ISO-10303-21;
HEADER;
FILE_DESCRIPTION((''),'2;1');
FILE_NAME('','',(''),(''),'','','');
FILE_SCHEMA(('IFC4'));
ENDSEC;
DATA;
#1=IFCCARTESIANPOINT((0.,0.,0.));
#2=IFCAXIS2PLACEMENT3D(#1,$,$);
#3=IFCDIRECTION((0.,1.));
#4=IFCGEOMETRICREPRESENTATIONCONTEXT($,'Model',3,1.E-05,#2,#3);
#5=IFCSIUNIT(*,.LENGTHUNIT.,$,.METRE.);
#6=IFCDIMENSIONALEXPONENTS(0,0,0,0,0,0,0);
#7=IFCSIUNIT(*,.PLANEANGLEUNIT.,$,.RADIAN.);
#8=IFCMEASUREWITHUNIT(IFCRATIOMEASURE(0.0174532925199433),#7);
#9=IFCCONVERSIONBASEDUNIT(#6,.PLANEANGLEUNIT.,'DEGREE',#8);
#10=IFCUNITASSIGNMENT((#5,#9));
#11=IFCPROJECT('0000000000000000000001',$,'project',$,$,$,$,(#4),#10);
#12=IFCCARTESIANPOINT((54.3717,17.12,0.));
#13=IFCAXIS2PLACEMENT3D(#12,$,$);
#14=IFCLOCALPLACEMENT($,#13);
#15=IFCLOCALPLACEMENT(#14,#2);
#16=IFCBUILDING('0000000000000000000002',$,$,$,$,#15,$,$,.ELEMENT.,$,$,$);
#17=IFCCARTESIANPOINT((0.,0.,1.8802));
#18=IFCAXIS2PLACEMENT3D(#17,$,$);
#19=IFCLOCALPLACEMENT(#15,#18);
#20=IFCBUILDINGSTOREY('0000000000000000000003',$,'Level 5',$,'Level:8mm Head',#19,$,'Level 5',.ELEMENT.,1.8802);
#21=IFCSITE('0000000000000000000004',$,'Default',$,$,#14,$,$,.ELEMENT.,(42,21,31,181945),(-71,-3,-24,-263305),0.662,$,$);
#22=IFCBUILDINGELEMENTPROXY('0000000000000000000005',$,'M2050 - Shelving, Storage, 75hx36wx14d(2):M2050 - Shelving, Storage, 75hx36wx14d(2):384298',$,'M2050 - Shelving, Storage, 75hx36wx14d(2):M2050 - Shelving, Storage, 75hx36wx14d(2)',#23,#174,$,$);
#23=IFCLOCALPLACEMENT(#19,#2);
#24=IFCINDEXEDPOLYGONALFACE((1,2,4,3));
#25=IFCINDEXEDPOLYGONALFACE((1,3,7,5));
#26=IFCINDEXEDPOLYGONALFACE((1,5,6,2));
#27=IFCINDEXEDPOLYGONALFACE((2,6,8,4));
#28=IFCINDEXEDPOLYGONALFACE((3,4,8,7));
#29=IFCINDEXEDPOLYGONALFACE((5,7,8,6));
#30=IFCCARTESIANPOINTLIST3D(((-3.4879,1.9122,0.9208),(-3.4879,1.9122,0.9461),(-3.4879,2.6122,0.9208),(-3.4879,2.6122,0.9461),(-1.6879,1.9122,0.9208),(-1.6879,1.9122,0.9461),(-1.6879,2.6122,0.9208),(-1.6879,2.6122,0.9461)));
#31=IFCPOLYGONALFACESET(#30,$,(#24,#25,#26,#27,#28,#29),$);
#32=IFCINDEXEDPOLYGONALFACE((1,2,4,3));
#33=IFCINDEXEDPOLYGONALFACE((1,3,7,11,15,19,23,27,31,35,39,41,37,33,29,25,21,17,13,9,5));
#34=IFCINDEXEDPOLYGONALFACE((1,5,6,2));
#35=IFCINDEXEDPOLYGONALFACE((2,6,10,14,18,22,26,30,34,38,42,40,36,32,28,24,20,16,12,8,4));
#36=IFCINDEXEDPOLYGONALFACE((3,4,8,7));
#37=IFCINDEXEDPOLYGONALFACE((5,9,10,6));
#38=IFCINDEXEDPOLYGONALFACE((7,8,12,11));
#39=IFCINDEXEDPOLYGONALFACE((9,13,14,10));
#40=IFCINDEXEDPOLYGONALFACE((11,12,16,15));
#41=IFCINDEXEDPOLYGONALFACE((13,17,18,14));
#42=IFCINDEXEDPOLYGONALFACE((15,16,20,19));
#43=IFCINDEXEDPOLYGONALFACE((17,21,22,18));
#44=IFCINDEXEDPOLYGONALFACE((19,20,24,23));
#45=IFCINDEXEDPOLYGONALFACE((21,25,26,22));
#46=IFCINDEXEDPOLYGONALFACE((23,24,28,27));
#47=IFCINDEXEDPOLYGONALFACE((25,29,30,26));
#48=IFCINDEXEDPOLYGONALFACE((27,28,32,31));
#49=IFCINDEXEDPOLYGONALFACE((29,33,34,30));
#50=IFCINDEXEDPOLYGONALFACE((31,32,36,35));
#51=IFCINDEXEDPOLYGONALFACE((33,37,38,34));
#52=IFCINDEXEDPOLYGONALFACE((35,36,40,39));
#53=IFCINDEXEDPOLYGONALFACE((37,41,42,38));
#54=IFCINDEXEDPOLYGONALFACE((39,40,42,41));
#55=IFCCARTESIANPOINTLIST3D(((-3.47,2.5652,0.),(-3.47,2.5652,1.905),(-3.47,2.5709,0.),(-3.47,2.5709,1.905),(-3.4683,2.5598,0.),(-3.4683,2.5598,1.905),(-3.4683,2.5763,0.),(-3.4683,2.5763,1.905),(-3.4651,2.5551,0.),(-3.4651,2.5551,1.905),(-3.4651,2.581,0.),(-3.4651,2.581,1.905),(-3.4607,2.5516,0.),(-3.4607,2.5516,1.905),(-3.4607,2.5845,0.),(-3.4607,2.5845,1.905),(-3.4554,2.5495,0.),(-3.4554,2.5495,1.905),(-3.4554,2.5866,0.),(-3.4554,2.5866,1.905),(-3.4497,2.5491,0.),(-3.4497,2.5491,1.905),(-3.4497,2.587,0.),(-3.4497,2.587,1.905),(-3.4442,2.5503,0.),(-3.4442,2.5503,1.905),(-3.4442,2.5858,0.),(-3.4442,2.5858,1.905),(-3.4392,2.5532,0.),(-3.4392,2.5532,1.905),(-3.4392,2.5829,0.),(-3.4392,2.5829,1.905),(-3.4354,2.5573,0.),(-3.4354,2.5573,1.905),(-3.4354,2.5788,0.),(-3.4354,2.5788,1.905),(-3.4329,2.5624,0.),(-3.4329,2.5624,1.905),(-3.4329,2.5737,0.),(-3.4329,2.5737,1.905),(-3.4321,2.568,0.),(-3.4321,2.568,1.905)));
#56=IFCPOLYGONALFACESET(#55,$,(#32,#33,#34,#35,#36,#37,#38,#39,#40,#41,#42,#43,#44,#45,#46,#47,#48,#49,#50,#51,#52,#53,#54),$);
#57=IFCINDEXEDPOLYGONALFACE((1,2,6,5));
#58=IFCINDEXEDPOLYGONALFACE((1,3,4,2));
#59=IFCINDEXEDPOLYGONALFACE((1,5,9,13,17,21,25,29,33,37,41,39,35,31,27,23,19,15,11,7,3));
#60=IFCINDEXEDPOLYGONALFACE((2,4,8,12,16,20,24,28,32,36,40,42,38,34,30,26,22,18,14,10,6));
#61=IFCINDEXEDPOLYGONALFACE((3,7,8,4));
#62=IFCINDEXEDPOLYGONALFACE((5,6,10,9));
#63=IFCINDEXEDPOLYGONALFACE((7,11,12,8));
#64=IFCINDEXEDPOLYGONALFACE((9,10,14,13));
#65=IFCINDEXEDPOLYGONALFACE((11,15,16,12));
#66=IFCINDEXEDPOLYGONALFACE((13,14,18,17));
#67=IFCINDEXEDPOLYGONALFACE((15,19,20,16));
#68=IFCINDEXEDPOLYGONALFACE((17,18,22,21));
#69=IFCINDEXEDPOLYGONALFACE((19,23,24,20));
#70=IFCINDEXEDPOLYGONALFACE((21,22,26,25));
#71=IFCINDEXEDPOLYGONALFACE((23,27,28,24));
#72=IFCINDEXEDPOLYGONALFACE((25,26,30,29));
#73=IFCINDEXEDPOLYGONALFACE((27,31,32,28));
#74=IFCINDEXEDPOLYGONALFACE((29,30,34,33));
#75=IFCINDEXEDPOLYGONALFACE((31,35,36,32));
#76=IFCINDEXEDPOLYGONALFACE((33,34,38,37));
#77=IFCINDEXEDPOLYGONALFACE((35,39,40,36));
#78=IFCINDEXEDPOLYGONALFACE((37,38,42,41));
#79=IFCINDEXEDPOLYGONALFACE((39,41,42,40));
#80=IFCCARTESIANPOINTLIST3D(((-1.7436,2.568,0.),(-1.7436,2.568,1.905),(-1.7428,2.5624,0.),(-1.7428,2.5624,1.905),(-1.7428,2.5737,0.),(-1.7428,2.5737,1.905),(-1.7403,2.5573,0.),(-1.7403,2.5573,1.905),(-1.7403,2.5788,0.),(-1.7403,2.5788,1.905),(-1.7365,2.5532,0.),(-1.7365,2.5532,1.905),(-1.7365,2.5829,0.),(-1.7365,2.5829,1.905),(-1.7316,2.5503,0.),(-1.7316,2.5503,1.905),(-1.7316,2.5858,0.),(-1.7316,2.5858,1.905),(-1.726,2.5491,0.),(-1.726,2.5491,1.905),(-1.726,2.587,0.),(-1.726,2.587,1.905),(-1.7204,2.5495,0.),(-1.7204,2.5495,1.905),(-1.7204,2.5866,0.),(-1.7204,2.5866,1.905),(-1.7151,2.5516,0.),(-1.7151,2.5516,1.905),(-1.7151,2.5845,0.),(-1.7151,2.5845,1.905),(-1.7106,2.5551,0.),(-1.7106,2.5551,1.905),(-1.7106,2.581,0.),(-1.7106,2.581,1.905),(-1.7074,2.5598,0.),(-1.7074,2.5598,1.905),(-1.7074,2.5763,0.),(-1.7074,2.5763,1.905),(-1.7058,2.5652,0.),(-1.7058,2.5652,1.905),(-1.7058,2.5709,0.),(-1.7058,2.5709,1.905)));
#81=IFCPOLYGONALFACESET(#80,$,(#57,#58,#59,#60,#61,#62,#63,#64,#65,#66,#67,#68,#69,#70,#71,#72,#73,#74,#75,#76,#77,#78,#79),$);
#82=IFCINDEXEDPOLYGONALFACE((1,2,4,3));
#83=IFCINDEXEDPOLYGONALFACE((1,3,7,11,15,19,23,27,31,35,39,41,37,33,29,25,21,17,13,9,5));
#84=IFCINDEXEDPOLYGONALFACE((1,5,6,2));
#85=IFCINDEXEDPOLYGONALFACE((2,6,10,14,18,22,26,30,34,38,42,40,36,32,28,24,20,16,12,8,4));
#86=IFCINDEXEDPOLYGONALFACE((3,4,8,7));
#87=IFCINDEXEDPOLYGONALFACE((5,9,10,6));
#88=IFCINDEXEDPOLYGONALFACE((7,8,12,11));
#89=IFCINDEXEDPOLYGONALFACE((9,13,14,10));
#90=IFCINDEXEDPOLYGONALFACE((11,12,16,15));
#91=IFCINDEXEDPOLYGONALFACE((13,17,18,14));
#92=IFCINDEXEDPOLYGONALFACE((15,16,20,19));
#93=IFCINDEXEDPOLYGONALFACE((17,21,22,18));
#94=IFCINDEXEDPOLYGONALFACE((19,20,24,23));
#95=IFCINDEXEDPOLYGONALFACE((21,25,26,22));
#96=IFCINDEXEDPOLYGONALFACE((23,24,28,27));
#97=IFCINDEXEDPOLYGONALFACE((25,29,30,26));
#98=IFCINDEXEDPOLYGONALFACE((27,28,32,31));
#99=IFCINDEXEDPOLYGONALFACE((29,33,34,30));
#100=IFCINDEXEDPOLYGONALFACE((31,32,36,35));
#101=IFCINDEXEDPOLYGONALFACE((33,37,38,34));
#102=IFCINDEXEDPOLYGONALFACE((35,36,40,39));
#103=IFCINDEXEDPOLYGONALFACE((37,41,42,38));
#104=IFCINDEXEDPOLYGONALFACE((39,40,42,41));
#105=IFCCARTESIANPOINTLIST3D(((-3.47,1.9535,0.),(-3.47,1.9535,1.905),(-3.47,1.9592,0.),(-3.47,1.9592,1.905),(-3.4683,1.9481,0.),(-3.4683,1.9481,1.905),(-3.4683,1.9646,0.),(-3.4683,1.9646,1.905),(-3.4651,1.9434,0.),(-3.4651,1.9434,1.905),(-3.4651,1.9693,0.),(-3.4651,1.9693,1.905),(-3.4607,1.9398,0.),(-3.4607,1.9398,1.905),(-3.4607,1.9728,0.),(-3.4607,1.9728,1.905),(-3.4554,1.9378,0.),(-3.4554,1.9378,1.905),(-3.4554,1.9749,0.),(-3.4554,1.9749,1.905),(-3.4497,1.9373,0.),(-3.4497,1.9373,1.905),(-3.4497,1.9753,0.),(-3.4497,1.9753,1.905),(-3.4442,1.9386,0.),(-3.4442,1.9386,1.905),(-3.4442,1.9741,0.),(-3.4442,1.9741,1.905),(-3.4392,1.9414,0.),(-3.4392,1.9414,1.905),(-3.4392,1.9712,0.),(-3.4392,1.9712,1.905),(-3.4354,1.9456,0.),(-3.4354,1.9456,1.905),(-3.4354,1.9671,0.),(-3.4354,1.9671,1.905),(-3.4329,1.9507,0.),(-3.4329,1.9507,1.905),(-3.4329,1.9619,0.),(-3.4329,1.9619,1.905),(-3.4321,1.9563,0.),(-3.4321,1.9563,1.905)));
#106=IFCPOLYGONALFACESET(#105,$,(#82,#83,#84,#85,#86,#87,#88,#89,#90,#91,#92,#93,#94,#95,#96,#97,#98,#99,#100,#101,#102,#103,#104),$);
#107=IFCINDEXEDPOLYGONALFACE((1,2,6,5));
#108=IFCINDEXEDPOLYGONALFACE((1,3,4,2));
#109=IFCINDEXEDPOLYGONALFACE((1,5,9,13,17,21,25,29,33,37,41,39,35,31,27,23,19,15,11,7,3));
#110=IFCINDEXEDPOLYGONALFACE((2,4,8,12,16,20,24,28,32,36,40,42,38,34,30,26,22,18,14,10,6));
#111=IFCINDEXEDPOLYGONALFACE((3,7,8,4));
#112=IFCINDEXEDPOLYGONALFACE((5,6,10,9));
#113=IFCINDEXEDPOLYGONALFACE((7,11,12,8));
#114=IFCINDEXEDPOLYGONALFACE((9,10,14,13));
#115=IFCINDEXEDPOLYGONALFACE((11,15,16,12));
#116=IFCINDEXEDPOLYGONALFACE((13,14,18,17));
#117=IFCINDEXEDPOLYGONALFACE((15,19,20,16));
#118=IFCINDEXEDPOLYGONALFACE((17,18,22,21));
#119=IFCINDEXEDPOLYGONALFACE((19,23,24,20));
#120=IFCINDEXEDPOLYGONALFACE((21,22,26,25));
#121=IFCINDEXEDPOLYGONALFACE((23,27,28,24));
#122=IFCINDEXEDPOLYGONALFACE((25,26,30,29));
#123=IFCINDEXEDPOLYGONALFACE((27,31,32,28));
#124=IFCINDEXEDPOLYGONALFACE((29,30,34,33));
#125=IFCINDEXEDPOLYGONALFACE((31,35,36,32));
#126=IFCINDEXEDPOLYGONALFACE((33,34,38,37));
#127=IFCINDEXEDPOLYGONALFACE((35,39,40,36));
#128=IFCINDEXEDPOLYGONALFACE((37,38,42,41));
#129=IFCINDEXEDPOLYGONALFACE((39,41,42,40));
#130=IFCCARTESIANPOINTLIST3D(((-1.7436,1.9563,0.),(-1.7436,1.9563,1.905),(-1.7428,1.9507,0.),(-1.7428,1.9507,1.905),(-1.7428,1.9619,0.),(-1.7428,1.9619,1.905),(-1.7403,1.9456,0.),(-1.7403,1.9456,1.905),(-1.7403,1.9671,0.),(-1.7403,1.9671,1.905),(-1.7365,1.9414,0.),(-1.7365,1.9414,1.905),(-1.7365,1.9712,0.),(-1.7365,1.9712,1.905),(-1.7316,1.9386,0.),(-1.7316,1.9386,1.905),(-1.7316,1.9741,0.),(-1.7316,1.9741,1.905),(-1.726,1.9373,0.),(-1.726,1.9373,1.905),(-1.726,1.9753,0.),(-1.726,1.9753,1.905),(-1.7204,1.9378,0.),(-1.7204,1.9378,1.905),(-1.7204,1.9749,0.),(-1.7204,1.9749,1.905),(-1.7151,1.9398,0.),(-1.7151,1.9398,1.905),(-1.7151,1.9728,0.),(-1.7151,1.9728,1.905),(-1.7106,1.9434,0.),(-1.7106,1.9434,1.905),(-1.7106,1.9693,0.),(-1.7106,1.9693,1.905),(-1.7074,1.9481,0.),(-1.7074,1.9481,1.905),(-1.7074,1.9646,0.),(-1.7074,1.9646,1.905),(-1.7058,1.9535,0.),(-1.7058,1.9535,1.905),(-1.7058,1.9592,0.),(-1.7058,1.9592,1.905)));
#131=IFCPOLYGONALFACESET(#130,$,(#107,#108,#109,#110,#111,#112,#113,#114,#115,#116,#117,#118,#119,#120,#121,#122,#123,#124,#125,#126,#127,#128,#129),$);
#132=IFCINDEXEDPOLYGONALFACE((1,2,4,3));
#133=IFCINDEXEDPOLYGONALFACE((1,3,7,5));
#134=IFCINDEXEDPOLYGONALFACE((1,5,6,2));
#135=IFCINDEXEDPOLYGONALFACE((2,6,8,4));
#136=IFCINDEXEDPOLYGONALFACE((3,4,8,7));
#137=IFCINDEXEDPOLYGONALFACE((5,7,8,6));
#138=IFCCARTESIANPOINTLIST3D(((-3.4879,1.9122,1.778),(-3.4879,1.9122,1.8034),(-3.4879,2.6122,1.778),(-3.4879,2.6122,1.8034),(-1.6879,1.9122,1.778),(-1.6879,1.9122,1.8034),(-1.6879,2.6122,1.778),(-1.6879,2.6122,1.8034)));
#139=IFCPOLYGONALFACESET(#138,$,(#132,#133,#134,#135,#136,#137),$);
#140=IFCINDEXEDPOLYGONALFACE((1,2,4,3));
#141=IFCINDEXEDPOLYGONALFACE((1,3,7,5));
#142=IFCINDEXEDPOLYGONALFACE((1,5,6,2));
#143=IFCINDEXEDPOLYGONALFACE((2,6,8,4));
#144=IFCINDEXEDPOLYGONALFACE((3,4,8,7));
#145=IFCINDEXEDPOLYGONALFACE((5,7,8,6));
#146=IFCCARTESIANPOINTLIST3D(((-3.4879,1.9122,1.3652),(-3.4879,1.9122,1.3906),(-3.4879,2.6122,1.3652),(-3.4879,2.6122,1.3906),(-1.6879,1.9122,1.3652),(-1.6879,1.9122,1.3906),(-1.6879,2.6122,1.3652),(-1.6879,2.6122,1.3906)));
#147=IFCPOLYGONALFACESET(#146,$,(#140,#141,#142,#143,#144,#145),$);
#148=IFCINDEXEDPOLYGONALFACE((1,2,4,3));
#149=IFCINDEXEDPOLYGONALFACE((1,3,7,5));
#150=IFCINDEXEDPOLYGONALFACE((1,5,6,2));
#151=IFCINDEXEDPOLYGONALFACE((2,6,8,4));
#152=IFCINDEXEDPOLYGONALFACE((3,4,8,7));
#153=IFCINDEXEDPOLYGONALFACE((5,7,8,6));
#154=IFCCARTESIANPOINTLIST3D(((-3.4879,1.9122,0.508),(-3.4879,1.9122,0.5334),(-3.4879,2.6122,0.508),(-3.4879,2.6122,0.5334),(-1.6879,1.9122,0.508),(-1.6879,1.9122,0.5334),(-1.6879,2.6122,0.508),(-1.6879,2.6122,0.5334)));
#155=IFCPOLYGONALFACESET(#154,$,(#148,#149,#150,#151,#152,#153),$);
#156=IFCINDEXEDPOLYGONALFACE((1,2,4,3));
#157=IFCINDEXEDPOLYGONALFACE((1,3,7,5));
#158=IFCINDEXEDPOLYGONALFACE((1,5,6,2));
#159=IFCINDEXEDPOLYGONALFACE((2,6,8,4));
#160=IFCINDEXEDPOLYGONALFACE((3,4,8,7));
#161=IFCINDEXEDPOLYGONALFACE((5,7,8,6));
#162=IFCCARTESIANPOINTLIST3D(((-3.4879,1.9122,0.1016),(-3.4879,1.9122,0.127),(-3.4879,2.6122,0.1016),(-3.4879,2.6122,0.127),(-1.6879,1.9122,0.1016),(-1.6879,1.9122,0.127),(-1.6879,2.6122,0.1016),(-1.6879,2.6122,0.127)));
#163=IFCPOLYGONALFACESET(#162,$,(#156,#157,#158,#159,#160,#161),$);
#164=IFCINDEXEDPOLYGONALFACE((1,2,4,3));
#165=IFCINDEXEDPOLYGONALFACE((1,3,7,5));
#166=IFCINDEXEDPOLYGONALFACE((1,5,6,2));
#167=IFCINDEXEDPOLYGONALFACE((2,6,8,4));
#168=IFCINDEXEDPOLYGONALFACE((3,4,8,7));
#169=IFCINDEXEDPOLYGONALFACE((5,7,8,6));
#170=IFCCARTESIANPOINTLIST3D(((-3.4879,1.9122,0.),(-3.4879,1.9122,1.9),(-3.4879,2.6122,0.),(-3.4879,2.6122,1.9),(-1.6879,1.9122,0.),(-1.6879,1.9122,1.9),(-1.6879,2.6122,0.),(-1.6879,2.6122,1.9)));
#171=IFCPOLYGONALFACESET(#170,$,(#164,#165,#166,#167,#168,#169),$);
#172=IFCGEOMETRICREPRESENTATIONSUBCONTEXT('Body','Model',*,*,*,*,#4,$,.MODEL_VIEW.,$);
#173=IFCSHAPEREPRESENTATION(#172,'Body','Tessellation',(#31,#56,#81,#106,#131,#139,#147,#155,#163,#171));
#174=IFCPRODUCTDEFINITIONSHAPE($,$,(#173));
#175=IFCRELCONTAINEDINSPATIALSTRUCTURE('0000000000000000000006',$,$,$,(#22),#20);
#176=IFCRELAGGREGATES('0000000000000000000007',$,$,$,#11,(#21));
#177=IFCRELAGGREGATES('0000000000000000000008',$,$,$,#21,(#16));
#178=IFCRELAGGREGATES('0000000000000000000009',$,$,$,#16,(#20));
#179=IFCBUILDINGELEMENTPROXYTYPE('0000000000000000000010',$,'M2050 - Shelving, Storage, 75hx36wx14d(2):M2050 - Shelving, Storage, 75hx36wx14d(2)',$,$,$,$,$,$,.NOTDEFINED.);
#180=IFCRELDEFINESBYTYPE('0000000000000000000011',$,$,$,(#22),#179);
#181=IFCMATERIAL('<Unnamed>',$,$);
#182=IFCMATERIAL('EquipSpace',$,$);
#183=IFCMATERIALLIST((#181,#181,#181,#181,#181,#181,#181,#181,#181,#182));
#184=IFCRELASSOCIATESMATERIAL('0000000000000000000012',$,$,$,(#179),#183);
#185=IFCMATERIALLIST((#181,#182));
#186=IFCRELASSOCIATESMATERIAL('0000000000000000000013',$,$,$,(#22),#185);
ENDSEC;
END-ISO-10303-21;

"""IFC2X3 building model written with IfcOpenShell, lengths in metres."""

from ifc_helpers import new_model, entity, si_unit, converted_unit, direction, frame, frame_2d, origin, origin_2d_with_axis, place, context, subcontext, project, spatial, rectangle, circle, extrude, source, transform, mapped, material, material_list, type_object, type_shapes, element, save


model = new_model("IFC2X3")

# Units and contexts
model_context = context("Model", 3, precision=1e-05, world=origin(), true_north=direction((0.0, 1.0)))
body_context = subcontext(model_context, "Body", "Model", "MODEL_VIEW")
ifc_project = project(units=[si_unit("LENGTHUNIT", "METRE"), converted_unit("PLANEANGLEUNIT", "DEGREE", entity("IfcRatioMeasure", 0.0174532925199433), si_unit("PLANEANGLEUNIT", "RADIAN"), dimensions=[0, 0, 0, 0, 0, 0, 0])], contexts=[model_context])

# Site, building, storey
site_placement = place(None, frame((54.3717, 17.12, 0.0)))
site = spatial("IfcSite", under=ifc_project, at=site_placement, Name="Default", CompositionType="ELEMENT", RefLatitude=(42, 21, 31, 181945), RefLongitude=(-71, -3, -24, -263305), RefElevation=0.662)
building_placement = place(site_placement, origin())
building = spatial("IfcBuilding", under=site, at=building_placement, CompositionType="ELEMENT")
storey_placement = place(building_placement, frame((0.0, 0.0, 1.8802)))
storey = spatial("IfcBuildingStorey", under=building, at=storey_placement, Name="Level 5", ObjectType="Level:8mm Head", LongName="Level 5", CompositionType="ELEMENT", Elevation=1.8802)

# Building element proxy
ifc_material_1 = material(Name="<Unnamed>")
ifc_material_2 = material(Name="EquipSpace")
ifc_material_list_1 = material_list([ifc_material_1, ifc_material_1, ifc_material_1, ifc_material_1, ifc_material_1, ifc_material_1, ifc_material_1, ifc_material_1, ifc_material_1, ifc_material_2])
building_element_proxy_type = type_object("IfcBuildingElementProxyType", Name="M2050 - Shelving, Storage, 75hx36wx14d(2):M2050 - Shelving, Storage, 75hx36wx14d(2)", PredefinedType="NOTDEFINED", material=ifc_material_list_1)
shared_shape = source(origin(), body_context, "Body", "SweptSolid", [
    extrude(rectangle(XDim=1.8, YDim=0.7, at=origin_2d_with_axis()), frame((0.0, 0.0, 0.9207), z_axis=(0.0, 0.0, 1.0), x_axis=(-1.0, 0.0, 0.0)), (0.0, 0.0, 1.0), 0.0254),
    extrude(circle(Radius=0.0191, at=origin_2d_with_axis()), frame((0.8633, -0.3059, 0.0), z_axis=(0.0, 0.0, 1.0), x_axis=(-1.0, 0.0, 0.0)), (0.0, 0.0, 1.0), 1.905),
    extrude(circle(Radius=0.0191, at=origin_2d_with_axis()), frame((-0.8633, -0.3059, 0.0)), (0.0, 0.0, 1.0), 1.905),
    extrude(circle(Radius=0.0191, at=origin_2d_with_axis()), frame((0.8633, 0.3059, 0.0), z_axis=(0.0, 0.0, 1.0), x_axis=(-1.0, 0.0, 0.0)), (0.0, 0.0, 1.0), 1.905),
    extrude(circle(Radius=0.0191, at=origin_2d_with_axis()), frame((-0.8633, 0.3059, 0.0)), (0.0, 0.0, 1.0), 1.905),
    extrude(rectangle(XDim=1.8, YDim=0.7, at=origin_2d_with_axis()), frame((0.0, 0.0, 1.778), z_axis=(0.0, 0.0, 1.0), x_axis=(-1.0, 0.0, 0.0)), (0.0, 0.0, 1.0), 0.0254),
    extrude(rectangle(XDim=1.8, YDim=0.7, at=origin_2d_with_axis()), frame((0.0, 0.0, 1.3653), z_axis=(0.0, 0.0, 1.0), x_axis=(-1.0, 0.0, 0.0)), (0.0, 0.0, 1.0), 0.0254),
    extrude(rectangle(XDim=1.8, YDim=0.7, at=origin_2d_with_axis()), frame((0.0, 0.0, 0.508), z_axis=(0.0, 0.0, 1.0), x_axis=(-1.0, 0.0, 0.0)), (0.0, 0.0, 1.0), 0.0254),
    extrude(rectangle(XDim=1.8, YDim=0.7, at=origin_2d_with_axis()), frame((0.0, 0.0, 0.1016), z_axis=(0.0, 0.0, 1.0), x_axis=(-1.0, 0.0, 0.0)), (0.0, 0.0, 1.0), 0.0254),
    extrude(rectangle(XDim=0.7, YDim=1.8, at=frame_2d((0.0, 0.18), x_axis=(1.0, 0.0))), frame((-0.18, 0.0, 0.0), z_axis=(0.0, 0.0, 1.0), x_axis=(0.0, -1.0, 0.0)), (0.0, 0.0, 1.0), 1.9),
])
type_shapes(building_element_proxy_type, [shared_shape])
ifc_material_list_2 = material_list([ifc_material_1, ifc_material_2])
proxy_1_placement = place(storey_placement, frame((-2.5879, 2.2622, 0.0), z_axis=(0.0, 0.0, 1.0), x_axis=(-1.0, 0.0, 0.0)))
element("IfcBuildingElementProxy", 1, at=proxy_1_placement, inside=storey, type_object=building_element_proxy_type, material=ifc_material_list_2, Name="M2050 - Shelving, Storage, 75hx36wx14d(2):M2050 - Shelving, Storage, 75hx36wx14d(2):384298", ObjectType="M2050 - Shelving, Storage, 75hx36wx14d(2):M2050 - Shelving, Storage, 75hx36wx14d(2)", context=body_context, shape_type="MappedRepresentation", body=[
    mapped(shared_shape, transform((0.0, 0.0, 0.0), scale=1.0)),
])

save(model, "model.ifc")
